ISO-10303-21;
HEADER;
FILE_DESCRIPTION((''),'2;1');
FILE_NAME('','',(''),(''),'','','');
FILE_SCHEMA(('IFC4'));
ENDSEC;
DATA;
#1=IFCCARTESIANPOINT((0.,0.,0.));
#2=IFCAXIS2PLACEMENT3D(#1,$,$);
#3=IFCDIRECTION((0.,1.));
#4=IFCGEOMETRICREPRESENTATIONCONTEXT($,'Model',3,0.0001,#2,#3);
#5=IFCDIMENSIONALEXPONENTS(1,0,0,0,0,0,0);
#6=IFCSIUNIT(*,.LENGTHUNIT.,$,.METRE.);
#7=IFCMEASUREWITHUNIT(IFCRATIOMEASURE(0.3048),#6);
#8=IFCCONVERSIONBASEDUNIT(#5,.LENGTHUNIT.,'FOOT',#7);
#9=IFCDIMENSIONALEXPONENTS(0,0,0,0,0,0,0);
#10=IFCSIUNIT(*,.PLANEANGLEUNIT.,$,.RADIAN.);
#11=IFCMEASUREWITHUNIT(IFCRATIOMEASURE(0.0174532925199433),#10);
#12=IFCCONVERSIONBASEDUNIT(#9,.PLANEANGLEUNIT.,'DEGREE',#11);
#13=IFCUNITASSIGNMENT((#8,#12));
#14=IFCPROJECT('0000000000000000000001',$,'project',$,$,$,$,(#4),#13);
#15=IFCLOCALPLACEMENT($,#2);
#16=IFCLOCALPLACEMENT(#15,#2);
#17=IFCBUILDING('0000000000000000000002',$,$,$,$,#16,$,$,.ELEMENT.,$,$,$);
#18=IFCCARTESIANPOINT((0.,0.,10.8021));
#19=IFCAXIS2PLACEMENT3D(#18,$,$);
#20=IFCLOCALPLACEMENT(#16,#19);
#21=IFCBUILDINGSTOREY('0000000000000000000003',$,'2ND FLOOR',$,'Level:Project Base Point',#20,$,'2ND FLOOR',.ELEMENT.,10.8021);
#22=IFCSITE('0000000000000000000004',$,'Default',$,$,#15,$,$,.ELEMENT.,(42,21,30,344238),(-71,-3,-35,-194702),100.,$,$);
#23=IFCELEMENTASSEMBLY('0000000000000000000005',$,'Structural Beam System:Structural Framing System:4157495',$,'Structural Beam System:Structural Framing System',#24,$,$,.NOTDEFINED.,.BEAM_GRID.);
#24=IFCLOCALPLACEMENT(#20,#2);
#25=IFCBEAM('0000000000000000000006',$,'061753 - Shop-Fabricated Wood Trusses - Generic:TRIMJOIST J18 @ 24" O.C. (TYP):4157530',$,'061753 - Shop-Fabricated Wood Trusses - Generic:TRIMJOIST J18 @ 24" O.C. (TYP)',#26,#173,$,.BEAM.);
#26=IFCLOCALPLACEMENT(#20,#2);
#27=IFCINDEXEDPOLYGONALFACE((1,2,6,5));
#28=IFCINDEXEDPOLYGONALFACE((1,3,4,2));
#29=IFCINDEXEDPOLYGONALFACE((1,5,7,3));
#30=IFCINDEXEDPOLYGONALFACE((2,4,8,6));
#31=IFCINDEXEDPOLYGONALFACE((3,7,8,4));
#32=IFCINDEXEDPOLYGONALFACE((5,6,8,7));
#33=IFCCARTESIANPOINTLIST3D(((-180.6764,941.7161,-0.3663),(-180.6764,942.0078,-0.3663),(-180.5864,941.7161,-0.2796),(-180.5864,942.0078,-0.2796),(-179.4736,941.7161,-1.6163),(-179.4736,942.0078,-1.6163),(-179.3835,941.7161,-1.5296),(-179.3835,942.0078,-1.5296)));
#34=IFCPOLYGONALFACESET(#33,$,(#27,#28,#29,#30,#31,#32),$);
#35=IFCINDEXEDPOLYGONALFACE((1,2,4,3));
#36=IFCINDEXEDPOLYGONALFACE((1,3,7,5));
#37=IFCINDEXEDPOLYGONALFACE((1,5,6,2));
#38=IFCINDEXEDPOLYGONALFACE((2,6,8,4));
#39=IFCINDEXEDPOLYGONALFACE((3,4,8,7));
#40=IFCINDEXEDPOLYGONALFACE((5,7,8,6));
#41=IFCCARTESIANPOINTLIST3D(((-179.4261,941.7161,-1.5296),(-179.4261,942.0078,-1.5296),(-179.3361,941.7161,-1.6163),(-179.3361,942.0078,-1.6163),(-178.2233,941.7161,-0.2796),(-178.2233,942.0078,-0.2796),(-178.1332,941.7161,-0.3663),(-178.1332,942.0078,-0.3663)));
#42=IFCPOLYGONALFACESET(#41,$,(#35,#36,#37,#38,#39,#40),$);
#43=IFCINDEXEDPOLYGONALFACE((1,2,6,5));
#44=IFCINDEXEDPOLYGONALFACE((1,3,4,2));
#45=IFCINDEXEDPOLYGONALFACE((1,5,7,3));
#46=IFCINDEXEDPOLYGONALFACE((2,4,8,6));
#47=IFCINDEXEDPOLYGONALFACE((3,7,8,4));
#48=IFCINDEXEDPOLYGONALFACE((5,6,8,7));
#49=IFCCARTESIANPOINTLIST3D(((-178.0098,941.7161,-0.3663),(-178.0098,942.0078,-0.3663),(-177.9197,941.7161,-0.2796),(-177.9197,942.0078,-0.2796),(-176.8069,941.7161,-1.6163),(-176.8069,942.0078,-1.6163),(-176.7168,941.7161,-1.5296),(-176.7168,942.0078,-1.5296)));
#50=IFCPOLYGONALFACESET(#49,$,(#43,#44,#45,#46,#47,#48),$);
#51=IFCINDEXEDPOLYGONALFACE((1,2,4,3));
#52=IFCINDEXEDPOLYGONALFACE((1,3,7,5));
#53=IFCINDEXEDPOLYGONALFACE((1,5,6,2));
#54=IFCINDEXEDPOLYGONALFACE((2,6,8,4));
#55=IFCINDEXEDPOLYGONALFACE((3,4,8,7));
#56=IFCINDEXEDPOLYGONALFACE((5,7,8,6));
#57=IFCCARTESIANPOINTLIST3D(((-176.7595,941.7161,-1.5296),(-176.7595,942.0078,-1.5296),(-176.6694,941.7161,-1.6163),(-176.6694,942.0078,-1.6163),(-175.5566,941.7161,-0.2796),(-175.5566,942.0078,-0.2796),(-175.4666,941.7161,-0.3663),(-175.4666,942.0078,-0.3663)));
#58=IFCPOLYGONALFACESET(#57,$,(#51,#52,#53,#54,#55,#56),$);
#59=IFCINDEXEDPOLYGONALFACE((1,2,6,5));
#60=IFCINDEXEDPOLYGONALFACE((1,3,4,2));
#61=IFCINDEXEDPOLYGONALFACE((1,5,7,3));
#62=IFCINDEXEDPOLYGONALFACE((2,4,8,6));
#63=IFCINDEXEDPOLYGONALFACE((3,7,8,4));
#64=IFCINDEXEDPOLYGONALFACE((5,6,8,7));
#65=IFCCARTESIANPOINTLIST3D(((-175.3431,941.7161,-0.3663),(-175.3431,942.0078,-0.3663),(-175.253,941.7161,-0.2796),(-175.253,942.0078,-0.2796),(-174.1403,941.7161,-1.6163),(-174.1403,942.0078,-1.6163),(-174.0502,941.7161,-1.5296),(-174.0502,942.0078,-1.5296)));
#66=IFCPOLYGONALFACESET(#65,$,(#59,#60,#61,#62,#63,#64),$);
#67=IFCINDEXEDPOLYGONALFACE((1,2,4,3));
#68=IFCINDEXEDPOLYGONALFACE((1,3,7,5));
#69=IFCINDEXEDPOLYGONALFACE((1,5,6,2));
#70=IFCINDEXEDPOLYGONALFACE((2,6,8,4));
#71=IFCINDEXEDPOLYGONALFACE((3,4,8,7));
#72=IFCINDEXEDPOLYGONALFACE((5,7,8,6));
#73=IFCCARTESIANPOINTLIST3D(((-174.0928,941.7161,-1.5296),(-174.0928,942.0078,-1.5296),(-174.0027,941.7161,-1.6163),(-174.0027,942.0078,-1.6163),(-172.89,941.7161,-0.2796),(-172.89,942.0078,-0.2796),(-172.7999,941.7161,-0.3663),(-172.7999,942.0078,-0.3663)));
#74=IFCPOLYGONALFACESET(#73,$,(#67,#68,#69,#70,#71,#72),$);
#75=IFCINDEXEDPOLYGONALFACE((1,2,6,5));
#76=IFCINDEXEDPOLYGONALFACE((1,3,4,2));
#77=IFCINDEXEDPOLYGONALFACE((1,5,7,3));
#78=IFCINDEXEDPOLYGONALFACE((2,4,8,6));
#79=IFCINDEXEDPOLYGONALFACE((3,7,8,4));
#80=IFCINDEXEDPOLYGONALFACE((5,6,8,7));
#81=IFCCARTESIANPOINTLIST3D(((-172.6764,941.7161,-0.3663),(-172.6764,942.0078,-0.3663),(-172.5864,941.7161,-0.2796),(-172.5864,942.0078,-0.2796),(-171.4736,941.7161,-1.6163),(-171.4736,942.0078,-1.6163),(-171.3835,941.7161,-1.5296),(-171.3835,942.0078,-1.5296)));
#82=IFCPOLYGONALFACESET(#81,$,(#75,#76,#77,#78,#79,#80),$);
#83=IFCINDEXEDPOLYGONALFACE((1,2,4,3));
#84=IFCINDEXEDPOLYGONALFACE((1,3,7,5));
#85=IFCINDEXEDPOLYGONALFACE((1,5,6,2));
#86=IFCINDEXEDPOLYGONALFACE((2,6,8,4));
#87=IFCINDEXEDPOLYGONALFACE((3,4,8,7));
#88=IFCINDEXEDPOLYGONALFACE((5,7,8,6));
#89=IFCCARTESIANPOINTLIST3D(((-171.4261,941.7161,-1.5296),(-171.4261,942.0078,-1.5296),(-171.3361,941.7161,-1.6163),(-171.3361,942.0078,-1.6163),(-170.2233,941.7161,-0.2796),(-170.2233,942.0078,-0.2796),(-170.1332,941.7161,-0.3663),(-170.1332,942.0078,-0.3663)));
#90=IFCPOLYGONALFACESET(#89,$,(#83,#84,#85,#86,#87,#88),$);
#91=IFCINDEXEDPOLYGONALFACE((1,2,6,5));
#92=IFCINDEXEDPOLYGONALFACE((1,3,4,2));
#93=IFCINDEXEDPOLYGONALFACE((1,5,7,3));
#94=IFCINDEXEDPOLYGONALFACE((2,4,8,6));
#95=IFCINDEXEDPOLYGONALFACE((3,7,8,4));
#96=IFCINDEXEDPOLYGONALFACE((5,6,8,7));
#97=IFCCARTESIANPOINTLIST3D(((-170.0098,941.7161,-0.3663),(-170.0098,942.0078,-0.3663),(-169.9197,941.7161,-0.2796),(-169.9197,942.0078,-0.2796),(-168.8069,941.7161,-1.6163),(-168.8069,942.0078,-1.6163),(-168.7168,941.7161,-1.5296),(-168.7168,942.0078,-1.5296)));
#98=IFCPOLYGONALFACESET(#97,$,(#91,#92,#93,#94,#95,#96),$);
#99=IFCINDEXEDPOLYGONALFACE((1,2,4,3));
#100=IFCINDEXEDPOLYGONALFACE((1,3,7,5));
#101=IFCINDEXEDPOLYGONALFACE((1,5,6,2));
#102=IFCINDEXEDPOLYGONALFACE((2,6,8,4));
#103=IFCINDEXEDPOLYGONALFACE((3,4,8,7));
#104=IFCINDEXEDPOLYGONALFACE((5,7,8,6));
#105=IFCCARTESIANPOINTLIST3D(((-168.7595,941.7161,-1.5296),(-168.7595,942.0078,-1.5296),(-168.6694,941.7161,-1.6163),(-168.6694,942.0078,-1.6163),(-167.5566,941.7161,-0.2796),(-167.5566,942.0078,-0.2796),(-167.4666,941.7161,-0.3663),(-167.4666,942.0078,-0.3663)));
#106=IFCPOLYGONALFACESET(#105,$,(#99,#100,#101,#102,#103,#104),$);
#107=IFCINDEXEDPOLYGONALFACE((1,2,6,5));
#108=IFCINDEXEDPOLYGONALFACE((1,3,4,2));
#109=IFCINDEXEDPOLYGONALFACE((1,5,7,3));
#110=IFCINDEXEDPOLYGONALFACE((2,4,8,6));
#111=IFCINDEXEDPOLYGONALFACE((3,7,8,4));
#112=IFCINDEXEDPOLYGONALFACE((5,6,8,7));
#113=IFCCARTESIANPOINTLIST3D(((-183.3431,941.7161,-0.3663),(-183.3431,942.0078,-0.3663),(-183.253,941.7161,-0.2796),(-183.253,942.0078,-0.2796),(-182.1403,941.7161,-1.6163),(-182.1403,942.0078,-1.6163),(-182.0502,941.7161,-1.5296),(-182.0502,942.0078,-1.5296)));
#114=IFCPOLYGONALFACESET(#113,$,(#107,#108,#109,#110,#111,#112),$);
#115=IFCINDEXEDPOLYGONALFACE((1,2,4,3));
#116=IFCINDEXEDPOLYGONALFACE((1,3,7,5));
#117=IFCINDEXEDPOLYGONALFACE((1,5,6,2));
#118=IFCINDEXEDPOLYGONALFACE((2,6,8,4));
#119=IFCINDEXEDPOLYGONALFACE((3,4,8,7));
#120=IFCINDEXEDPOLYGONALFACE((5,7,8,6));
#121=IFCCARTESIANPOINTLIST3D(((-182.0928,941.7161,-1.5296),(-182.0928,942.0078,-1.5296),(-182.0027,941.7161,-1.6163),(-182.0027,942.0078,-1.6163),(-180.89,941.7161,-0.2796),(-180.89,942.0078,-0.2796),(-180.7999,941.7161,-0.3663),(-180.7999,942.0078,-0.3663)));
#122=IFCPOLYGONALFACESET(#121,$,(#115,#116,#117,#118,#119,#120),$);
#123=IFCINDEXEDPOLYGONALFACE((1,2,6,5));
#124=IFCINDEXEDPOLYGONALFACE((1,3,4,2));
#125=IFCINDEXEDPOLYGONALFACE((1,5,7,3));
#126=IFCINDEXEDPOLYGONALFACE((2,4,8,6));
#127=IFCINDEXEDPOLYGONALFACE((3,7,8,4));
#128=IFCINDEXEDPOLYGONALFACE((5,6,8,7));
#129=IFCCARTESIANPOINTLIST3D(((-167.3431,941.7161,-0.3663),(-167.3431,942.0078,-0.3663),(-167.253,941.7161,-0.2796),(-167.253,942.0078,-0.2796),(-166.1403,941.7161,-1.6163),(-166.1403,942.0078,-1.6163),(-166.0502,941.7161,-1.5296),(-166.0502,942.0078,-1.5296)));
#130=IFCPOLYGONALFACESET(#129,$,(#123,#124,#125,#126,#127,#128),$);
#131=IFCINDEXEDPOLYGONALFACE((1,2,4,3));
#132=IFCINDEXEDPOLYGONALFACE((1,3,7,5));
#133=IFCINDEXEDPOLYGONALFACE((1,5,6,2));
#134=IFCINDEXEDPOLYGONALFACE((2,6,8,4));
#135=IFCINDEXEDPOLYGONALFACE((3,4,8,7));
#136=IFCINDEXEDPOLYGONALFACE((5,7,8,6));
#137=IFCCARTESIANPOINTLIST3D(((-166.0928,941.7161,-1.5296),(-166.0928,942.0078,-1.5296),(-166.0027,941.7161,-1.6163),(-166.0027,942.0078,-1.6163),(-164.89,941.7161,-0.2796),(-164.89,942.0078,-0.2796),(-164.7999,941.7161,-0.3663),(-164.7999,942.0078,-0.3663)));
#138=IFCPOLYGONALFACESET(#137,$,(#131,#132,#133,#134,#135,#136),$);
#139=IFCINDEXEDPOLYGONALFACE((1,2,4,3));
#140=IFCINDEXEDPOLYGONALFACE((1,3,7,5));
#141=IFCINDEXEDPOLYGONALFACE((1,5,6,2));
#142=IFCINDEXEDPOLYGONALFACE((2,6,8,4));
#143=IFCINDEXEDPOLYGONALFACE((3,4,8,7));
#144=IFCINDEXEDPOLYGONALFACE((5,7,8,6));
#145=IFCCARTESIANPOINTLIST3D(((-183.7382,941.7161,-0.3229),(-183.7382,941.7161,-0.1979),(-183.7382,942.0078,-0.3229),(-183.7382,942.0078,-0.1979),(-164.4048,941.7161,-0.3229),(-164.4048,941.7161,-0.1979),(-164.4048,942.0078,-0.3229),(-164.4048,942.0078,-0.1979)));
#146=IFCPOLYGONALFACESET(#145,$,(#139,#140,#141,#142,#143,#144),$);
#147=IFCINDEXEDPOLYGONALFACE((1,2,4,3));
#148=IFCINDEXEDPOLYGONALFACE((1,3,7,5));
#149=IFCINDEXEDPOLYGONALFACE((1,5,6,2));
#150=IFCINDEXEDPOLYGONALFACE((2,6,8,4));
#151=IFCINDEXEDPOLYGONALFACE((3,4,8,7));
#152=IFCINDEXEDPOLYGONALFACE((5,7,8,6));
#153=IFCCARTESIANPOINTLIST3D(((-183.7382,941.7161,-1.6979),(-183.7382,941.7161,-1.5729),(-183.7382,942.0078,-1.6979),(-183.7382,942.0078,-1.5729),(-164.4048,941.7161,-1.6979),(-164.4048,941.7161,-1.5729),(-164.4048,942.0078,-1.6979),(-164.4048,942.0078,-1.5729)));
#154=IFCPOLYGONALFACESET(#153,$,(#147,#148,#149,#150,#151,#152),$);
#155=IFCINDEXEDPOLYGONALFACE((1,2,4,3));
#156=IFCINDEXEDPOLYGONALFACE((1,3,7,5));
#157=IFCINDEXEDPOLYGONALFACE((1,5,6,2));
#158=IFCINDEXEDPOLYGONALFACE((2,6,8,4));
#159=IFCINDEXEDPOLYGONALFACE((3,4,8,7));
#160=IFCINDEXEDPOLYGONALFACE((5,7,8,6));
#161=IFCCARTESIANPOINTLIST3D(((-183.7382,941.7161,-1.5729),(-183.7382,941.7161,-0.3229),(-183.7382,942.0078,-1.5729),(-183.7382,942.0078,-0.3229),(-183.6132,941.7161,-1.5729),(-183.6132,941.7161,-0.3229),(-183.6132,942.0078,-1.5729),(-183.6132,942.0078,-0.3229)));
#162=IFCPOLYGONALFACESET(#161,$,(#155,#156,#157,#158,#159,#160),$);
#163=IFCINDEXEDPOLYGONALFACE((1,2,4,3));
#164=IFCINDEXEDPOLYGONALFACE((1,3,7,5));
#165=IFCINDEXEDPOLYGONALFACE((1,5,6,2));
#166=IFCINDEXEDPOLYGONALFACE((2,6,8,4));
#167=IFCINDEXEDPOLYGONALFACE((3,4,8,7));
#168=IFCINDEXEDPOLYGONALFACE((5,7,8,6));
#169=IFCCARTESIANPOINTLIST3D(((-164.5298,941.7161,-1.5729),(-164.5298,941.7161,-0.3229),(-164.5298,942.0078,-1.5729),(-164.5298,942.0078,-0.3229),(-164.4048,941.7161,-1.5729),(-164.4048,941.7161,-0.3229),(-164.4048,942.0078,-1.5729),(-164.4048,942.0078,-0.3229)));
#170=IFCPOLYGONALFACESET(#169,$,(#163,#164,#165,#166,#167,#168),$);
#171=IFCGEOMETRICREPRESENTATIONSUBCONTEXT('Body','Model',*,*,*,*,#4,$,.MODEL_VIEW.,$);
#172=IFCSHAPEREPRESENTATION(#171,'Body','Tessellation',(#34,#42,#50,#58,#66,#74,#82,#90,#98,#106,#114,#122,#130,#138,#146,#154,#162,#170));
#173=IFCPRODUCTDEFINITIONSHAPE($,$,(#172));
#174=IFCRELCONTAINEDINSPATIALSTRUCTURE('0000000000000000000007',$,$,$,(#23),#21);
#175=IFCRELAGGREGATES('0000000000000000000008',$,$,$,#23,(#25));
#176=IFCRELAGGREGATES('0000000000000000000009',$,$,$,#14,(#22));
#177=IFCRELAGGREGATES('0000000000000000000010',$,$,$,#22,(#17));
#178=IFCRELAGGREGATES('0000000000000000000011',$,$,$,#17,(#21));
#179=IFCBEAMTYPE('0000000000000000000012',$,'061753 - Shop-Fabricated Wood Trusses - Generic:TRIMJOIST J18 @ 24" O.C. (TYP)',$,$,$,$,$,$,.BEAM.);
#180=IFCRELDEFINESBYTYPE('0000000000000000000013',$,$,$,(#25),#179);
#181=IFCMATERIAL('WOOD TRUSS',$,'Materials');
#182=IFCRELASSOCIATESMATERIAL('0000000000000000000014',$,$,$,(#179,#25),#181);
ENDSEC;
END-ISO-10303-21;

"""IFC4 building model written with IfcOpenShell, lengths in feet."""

from ifc_helpers import new_model, entity, si_unit, converted_unit, direction, frame, frame_2d, origin, origin_2d_with_axis, place, context, subcontext, project, spatial, rectangle, extrude, source, transform, mapped, material, material_profile, profile_set, profile_usage, type_object, type_shapes, element, aggregate, save


model = new_model("IFC4")

# Units and contexts
model_context = context("Model", 3, precision=0.0001, world=origin(), true_north=direction((0.0, 1.0)))
body_context = subcontext(model_context, "Body", "Model", "MODEL_VIEW")
ifc_project = project(units=[converted_unit("LENGTHUNIT", "FOOT", entity("IfcRatioMeasure", 0.3048), si_unit("LENGTHUNIT", "METRE"), dimensions=[1, 0, 0, 0, 0, 0, 0]), converted_unit("PLANEANGLEUNIT", "DEGREE", entity("IfcRatioMeasure", 0.0174532925199433), si_unit("PLANEANGLEUNIT", "RADIAN"), dimensions=[0, 0, 0, 0, 0, 0, 0])], contexts=[model_context])

# Site, building, storey
site_placement = place(None, origin())
site = spatial("IfcSite", under=ifc_project, at=site_placement, Name="Default", CompositionType="ELEMENT", RefLatitude=(42, 21, 30, 344238), RefLongitude=(-71, -3, -35, -194702), RefElevation=100.0)
building_placement = place(site_placement, origin())
building = spatial("IfcBuilding", under=site, at=building_placement, CompositionType="ELEMENT")
storey_placement = place(building_placement, frame((0.0, 0.0, 10.8021)))
storey = spatial("IfcBuildingStorey", under=building, at=storey_placement, Name="2ND FLOOR", ObjectType="Level:Project Base Point", LongName="2ND FLOOR", CompositionType="ELEMENT", Elevation=10.8021)

# Element assembly, beam
assembly_1_placement = place(storey_placement, origin())
assembly_1 = element("IfcElementAssembly", 1, at=assembly_1_placement, inside=storey, Name="Structural Beam System:Structural Framing System:4157495", ObjectType="Structural Beam System:Structural Framing System", AssemblyPlace="NOTDEFINED", PredefinedType="BEAM_GRID")
ifc_material_1 = material(Name="WOOD TRUSS", Category="Materials")
ifc_material_profile_1 = material_profile(ifc_material_1, rectangle(XDim=1.7347, YDim=0.125, at=frame_2d((0.0, 0.0), x_axis=(1.0, 0.0))), Name="TRIMJOIST J18 @ 24\" O.C. (TYP)")
ifc_material_profile_2 = material_profile(ifc_material_1, rectangle(XDim=1.7347, YDim=0.125, at=frame_2d((0.0, 0.0), x_axis=(1.0, 0.0))), Name="TRIMJOIST J18 @ 24\" O.C. (TYP)")
ifc_material_profile_3 = material_profile(ifc_material_1, rectangle(XDim=1.7347, YDim=0.125, at=frame_2d((0.0, 0.0), x_axis=(1.0, 0.0))), Name="TRIMJOIST J18 @ 24\" O.C. (TYP)")
ifc_material_profile_4 = material_profile(ifc_material_1, rectangle(XDim=1.7347, YDim=0.125, at=frame_2d((0.0, 0.0), x_axis=(1.0, 0.0))), Name="TRIMJOIST J18 @ 24\" O.C. (TYP)")
ifc_material_profile_5 = material_profile(ifc_material_1, rectangle(XDim=1.7347, YDim=0.125, at=frame_2d((0.0, 0.0), x_axis=(1.0, 0.0))), Name="TRIMJOIST J18 @ 24\" O.C. (TYP)")
ifc_material_profile_6 = material_profile(ifc_material_1, rectangle(XDim=1.7347, YDim=0.125, at=frame_2d((0.0, 0.0), x_axis=(1.0, 0.0))), Name="TRIMJOIST J18 @ 24\" O.C. (TYP)")
ifc_material_profile_7 = material_profile(ifc_material_1, rectangle(XDim=1.7347, YDim=0.125, at=frame_2d((0.0, 0.0), x_axis=(1.0, 0.0))), Name="TRIMJOIST J18 @ 24\" O.C. (TYP)")
ifc_material_profile_8 = material_profile(ifc_material_1, rectangle(XDim=1.7347, YDim=0.125, at=frame_2d((0.0, 0.0), x_axis=(1.0, 0.0))), Name="TRIMJOIST J18 @ 24\" O.C. (TYP)")
ifc_material_profile_9 = material_profile(ifc_material_1, rectangle(XDim=1.7347, YDim=0.125, at=frame_2d((0.0, 0.0), x_axis=(1.0, 0.0))), Name="TRIMJOIST J18 @ 24\" O.C. (TYP)")
ifc_material_profile_10 = material_profile(ifc_material_1, rectangle(XDim=1.7347, YDim=0.125, at=origin_2d_with_axis()), Name="TRIMJOIST J18 @ 24\" O.C. (TYP)")
ifc_material_profile_11 = material_profile(ifc_material_1, rectangle(XDim=0.125, YDim=0.2917, at=origin_2d_with_axis()), Name="TRIMJOIST J18 @ 24\" O.C. (TYP)")
ifc_material_profile_12 = material_profile(ifc_material_1, rectangle(XDim=0.125, YDim=0.2917, at=origin_2d_with_axis()), Name="TRIMJOIST J18 @ 24\" O.C. (TYP)")
ifc_material_profile_13 = material_profile(ifc_material_1, rectangle(XDim=1.25, YDim=0.2917, at=origin_2d_with_axis()), Name="TRIMJOIST J18 @ 24\" O.C. (TYP)")
ifc_material_profile_14 = material_profile(ifc_material_1, rectangle(XDim=1.25, YDim=0.2917, at=origin_2d_with_axis()), Name="TRIMJOIST J18 @ 24\" O.C. (TYP)")
ifc_profile_set_1 = profile_set([ifc_material_profile_1, ifc_material_profile_2, ifc_material_profile_3, ifc_material_profile_4, ifc_material_profile_5, ifc_material_profile_6, ifc_material_profile_7, ifc_material_profile_8, ifc_material_profile_9, ifc_material_profile_10, ifc_material_profile_11, ifc_material_profile_12, ifc_material_profile_13, ifc_material_profile_14], Name="TRIMJOIST J18 @ 24\" O.C. (TYP)")
beam_type_1 = type_object("IfcBeamType", Name="061753 - Shop-Fabricated Wood Trusses - Generic:TRIMJOIST J18 @ 24\" O.C. (TYP)", PredefinedType="BEAM", material=ifc_profile_set_1)
shared_shape_1 = source(origin(), body_context, "Body", "SweptSolid", [
    extrude(rectangle(XDim=1.7347, YDim=0.125, at=frame_2d((0.0, 0.0), x_axis=(1.0, 0.0))), frame((5.9585, -0.1458, 0.0), z_axis=(0.0, 1.0, 0.0), x_axis=(0.693383, 0.0, 0.720569)), (0.0, 0.0, 1.0), 0.2917),
    extrude(rectangle(XDim=1.7347, YDim=0.125, at=origin_2d_with_axis()), frame((4.7082, -0.1458, 0.0), z_axis=(0.0, 1.0, 0.0), x_axis=(0.693383, 0.0, -0.720569)), (0.0, 0.0, 1.0), 0.2917),
    extrude(rectangle(XDim=1.7347, YDim=0.125, at=frame_2d((0.0, 0.0), x_axis=(1.0, 0.0))), frame((3.2918, -0.1458, 0.0), z_axis=(0.0, 1.0, 0.0), x_axis=(0.693383, 0.0, 0.720569)), (0.0, 0.0, 1.0), 0.2917),
    extrude(rectangle(XDim=1.7347, YDim=0.125, at=frame_2d((0.0, 0.0), x_axis=(1.0, 0.0))), frame((2.0415, -0.1458, 0.0), z_axis=(0.0, 1.0, 0.0), x_axis=(0.693383, 0.0, -0.720569)), (0.0, 0.0, 1.0), 0.2917),
    extrude(rectangle(XDim=1.7347, YDim=0.125, at=frame_2d((0.0, 0.0), x_axis=(1.0, 0.0))), frame((0.6251, -0.1458, 0.0), z_axis=(0.0, 1.0, 0.0), x_axis=(0.693383, 0.0, 0.720569)), (0.0, 0.0, 1.0), 0.2917),
    extrude(rectangle(XDim=1.7347, YDim=0.125, at=frame_2d((0.0, 0.0), x_axis=(1.0, 0.0))), frame((-0.6251, -0.1458, 0.0), z_axis=(0.0, 1.0, 0.0), x_axis=(0.693383, 0.0, -0.720569)), (0.0, 0.0, 1.0), 0.2917),
    extrude(rectangle(XDim=1.7347, YDim=0.125, at=frame_2d((0.0, 0.0), x_axis=(1.0, 0.0))), frame((-2.0415, -0.1458, 0.0), z_axis=(0.0, 1.0, 0.0), x_axis=(0.693383, 0.0, 0.720569)), (0.0, 0.0, 1.0), 0.2917),
    extrude(rectangle(XDim=1.7347, YDim=0.125, at=origin_2d_with_axis()), frame((-3.2918, -0.1458, 0.0), z_axis=(0.0, 1.0, 0.0), x_axis=(0.693383, 0.0, -0.720569)), (0.0, 0.0, 1.0), 0.2917),
    extrude(rectangle(XDim=1.7347, YDim=0.125, at=frame_2d((0.0, 0.0), x_axis=(1.0, 0.0))), frame((-4.7082, -0.1458, 0.0), z_axis=(0.0, 1.0, 0.0), x_axis=(0.693383, 0.0, 0.720569)), (0.0, 0.0, 1.0), 0.2917),
    extrude(rectangle(XDim=1.7347, YDim=0.125, at=frame_2d((0.0, 0.0), x_axis=(1.0, 0.0))), frame((-5.9585, -0.1458, 0.0), z_axis=(0.0, 1.0, 0.0), x_axis=(0.693383, 0.0, -0.720569)), (0.0, 0.0, 1.0), 0.2917),
    extrude(rectangle(XDim=1.7347, YDim=0.125, at=frame_2d((0.0, 0.0), x_axis=(1.0, 0.0))), frame((8.6251, -0.1458, 0.0), z_axis=(0.0, 1.0, 0.0), x_axis=(0.693383, 0.0, 0.720569)), (0.0, 0.0, 1.0), 0.2917),
    extrude(rectangle(XDim=1.7347, YDim=0.125, at=origin_2d_with_axis()), frame((7.3749, -0.1458, 0.0), z_axis=(0.0, 1.0, 0.0), x_axis=(0.693383, 0.0, -0.720569)), (0.0, 0.0, 1.0), 0.2917),
    extrude(rectangle(XDim=1.7347, YDim=0.125, at=frame_2d((0.0, 0.0), x_axis=(1.0, 0.0))), frame((-7.3749, -0.1458, 0.0), z_axis=(0.0, 1.0, 0.0), x_axis=(0.693383, 0.0, 0.720569)), (0.0, 0.0, 1.0), 0.2917),
    extrude(rectangle(XDim=1.7347, YDim=0.125, at=origin_2d_with_axis()), frame((-8.6251, -0.1458, 0.0), z_axis=(0.0, 1.0, 0.0), x_axis=(0.693383, 0.0, -0.720569)), (0.0, 0.0, 1.0), 0.2917),
    extrude(rectangle(XDim=0.125, YDim=0.2917, at=origin_2d_with_axis()), frame((-9.6667, 0.0, 0.6875), z_axis=(1.0, 0.0, 0.0), x_axis=(0.0, 0.0, -1.0)), (0.0, 0.0, 1.0), 19.3333),
    extrude(rectangle(XDim=0.125, YDim=0.2917, at=origin_2d_with_axis()), frame((-9.6667, 0.0, -0.6875), z_axis=(1.0, 0.0, 0.0), x_axis=(0.0, 0.0, -1.0)), (0.0, 0.0, 1.0), 19.3333),
    extrude(rectangle(XDim=1.25, YDim=0.2917, at=origin_2d_with_axis()), frame((9.5417, 0.0, 0.0), z_axis=(1.0, 0.0, 0.0), x_axis=(0.0, 0.0, -1.0)), (0.0, 0.0, 1.0), 0.125),
    extrude(rectangle(XDim=1.25, YDim=0.2917, at=origin_2d_with_axis()), frame((-9.6667, 0.0, 0.0), z_axis=(1.0, 0.0, 0.0), x_axis=(0.0, 0.0, -1.0)), (0.0, 0.0, 1.0), 0.125),
])
type_shapes(beam_type_1, [shared_shape_1])
ifc_profile_usage_1 = profile_usage(ifc_profile_set_1, cardinal=8)
beam_1_placement = place(assembly_1_placement, frame((-174.0715, 941.8619, -0.9479), z_axis=(0.0, 0.0, 1.0), x_axis=(-1.0, 0.0, 0.0)))
beam_1 = element("IfcBeam", 2, at=beam_1_placement, type_object=beam_type_1, material=ifc_profile_usage_1, Name="061753 - Shop-Fabricated Wood Trusses - Generic:TRIMJOIST J18 @ 24\" O.C. (TYP):4157530", ObjectType="061753 - Shop-Fabricated Wood Trusses - Generic:TRIMJOIST J18 @ 24\" O.C. (TYP)", PredefinedType="BEAM", context=body_context, shape_type="MappedRepresentation", body=[
    mapped(shared_shape_1, transform((0.0, 0.0, 0.0), scale=1.0)),
])
aggregate(assembly_1, [beam_1])

save(model, "model.ifc")
